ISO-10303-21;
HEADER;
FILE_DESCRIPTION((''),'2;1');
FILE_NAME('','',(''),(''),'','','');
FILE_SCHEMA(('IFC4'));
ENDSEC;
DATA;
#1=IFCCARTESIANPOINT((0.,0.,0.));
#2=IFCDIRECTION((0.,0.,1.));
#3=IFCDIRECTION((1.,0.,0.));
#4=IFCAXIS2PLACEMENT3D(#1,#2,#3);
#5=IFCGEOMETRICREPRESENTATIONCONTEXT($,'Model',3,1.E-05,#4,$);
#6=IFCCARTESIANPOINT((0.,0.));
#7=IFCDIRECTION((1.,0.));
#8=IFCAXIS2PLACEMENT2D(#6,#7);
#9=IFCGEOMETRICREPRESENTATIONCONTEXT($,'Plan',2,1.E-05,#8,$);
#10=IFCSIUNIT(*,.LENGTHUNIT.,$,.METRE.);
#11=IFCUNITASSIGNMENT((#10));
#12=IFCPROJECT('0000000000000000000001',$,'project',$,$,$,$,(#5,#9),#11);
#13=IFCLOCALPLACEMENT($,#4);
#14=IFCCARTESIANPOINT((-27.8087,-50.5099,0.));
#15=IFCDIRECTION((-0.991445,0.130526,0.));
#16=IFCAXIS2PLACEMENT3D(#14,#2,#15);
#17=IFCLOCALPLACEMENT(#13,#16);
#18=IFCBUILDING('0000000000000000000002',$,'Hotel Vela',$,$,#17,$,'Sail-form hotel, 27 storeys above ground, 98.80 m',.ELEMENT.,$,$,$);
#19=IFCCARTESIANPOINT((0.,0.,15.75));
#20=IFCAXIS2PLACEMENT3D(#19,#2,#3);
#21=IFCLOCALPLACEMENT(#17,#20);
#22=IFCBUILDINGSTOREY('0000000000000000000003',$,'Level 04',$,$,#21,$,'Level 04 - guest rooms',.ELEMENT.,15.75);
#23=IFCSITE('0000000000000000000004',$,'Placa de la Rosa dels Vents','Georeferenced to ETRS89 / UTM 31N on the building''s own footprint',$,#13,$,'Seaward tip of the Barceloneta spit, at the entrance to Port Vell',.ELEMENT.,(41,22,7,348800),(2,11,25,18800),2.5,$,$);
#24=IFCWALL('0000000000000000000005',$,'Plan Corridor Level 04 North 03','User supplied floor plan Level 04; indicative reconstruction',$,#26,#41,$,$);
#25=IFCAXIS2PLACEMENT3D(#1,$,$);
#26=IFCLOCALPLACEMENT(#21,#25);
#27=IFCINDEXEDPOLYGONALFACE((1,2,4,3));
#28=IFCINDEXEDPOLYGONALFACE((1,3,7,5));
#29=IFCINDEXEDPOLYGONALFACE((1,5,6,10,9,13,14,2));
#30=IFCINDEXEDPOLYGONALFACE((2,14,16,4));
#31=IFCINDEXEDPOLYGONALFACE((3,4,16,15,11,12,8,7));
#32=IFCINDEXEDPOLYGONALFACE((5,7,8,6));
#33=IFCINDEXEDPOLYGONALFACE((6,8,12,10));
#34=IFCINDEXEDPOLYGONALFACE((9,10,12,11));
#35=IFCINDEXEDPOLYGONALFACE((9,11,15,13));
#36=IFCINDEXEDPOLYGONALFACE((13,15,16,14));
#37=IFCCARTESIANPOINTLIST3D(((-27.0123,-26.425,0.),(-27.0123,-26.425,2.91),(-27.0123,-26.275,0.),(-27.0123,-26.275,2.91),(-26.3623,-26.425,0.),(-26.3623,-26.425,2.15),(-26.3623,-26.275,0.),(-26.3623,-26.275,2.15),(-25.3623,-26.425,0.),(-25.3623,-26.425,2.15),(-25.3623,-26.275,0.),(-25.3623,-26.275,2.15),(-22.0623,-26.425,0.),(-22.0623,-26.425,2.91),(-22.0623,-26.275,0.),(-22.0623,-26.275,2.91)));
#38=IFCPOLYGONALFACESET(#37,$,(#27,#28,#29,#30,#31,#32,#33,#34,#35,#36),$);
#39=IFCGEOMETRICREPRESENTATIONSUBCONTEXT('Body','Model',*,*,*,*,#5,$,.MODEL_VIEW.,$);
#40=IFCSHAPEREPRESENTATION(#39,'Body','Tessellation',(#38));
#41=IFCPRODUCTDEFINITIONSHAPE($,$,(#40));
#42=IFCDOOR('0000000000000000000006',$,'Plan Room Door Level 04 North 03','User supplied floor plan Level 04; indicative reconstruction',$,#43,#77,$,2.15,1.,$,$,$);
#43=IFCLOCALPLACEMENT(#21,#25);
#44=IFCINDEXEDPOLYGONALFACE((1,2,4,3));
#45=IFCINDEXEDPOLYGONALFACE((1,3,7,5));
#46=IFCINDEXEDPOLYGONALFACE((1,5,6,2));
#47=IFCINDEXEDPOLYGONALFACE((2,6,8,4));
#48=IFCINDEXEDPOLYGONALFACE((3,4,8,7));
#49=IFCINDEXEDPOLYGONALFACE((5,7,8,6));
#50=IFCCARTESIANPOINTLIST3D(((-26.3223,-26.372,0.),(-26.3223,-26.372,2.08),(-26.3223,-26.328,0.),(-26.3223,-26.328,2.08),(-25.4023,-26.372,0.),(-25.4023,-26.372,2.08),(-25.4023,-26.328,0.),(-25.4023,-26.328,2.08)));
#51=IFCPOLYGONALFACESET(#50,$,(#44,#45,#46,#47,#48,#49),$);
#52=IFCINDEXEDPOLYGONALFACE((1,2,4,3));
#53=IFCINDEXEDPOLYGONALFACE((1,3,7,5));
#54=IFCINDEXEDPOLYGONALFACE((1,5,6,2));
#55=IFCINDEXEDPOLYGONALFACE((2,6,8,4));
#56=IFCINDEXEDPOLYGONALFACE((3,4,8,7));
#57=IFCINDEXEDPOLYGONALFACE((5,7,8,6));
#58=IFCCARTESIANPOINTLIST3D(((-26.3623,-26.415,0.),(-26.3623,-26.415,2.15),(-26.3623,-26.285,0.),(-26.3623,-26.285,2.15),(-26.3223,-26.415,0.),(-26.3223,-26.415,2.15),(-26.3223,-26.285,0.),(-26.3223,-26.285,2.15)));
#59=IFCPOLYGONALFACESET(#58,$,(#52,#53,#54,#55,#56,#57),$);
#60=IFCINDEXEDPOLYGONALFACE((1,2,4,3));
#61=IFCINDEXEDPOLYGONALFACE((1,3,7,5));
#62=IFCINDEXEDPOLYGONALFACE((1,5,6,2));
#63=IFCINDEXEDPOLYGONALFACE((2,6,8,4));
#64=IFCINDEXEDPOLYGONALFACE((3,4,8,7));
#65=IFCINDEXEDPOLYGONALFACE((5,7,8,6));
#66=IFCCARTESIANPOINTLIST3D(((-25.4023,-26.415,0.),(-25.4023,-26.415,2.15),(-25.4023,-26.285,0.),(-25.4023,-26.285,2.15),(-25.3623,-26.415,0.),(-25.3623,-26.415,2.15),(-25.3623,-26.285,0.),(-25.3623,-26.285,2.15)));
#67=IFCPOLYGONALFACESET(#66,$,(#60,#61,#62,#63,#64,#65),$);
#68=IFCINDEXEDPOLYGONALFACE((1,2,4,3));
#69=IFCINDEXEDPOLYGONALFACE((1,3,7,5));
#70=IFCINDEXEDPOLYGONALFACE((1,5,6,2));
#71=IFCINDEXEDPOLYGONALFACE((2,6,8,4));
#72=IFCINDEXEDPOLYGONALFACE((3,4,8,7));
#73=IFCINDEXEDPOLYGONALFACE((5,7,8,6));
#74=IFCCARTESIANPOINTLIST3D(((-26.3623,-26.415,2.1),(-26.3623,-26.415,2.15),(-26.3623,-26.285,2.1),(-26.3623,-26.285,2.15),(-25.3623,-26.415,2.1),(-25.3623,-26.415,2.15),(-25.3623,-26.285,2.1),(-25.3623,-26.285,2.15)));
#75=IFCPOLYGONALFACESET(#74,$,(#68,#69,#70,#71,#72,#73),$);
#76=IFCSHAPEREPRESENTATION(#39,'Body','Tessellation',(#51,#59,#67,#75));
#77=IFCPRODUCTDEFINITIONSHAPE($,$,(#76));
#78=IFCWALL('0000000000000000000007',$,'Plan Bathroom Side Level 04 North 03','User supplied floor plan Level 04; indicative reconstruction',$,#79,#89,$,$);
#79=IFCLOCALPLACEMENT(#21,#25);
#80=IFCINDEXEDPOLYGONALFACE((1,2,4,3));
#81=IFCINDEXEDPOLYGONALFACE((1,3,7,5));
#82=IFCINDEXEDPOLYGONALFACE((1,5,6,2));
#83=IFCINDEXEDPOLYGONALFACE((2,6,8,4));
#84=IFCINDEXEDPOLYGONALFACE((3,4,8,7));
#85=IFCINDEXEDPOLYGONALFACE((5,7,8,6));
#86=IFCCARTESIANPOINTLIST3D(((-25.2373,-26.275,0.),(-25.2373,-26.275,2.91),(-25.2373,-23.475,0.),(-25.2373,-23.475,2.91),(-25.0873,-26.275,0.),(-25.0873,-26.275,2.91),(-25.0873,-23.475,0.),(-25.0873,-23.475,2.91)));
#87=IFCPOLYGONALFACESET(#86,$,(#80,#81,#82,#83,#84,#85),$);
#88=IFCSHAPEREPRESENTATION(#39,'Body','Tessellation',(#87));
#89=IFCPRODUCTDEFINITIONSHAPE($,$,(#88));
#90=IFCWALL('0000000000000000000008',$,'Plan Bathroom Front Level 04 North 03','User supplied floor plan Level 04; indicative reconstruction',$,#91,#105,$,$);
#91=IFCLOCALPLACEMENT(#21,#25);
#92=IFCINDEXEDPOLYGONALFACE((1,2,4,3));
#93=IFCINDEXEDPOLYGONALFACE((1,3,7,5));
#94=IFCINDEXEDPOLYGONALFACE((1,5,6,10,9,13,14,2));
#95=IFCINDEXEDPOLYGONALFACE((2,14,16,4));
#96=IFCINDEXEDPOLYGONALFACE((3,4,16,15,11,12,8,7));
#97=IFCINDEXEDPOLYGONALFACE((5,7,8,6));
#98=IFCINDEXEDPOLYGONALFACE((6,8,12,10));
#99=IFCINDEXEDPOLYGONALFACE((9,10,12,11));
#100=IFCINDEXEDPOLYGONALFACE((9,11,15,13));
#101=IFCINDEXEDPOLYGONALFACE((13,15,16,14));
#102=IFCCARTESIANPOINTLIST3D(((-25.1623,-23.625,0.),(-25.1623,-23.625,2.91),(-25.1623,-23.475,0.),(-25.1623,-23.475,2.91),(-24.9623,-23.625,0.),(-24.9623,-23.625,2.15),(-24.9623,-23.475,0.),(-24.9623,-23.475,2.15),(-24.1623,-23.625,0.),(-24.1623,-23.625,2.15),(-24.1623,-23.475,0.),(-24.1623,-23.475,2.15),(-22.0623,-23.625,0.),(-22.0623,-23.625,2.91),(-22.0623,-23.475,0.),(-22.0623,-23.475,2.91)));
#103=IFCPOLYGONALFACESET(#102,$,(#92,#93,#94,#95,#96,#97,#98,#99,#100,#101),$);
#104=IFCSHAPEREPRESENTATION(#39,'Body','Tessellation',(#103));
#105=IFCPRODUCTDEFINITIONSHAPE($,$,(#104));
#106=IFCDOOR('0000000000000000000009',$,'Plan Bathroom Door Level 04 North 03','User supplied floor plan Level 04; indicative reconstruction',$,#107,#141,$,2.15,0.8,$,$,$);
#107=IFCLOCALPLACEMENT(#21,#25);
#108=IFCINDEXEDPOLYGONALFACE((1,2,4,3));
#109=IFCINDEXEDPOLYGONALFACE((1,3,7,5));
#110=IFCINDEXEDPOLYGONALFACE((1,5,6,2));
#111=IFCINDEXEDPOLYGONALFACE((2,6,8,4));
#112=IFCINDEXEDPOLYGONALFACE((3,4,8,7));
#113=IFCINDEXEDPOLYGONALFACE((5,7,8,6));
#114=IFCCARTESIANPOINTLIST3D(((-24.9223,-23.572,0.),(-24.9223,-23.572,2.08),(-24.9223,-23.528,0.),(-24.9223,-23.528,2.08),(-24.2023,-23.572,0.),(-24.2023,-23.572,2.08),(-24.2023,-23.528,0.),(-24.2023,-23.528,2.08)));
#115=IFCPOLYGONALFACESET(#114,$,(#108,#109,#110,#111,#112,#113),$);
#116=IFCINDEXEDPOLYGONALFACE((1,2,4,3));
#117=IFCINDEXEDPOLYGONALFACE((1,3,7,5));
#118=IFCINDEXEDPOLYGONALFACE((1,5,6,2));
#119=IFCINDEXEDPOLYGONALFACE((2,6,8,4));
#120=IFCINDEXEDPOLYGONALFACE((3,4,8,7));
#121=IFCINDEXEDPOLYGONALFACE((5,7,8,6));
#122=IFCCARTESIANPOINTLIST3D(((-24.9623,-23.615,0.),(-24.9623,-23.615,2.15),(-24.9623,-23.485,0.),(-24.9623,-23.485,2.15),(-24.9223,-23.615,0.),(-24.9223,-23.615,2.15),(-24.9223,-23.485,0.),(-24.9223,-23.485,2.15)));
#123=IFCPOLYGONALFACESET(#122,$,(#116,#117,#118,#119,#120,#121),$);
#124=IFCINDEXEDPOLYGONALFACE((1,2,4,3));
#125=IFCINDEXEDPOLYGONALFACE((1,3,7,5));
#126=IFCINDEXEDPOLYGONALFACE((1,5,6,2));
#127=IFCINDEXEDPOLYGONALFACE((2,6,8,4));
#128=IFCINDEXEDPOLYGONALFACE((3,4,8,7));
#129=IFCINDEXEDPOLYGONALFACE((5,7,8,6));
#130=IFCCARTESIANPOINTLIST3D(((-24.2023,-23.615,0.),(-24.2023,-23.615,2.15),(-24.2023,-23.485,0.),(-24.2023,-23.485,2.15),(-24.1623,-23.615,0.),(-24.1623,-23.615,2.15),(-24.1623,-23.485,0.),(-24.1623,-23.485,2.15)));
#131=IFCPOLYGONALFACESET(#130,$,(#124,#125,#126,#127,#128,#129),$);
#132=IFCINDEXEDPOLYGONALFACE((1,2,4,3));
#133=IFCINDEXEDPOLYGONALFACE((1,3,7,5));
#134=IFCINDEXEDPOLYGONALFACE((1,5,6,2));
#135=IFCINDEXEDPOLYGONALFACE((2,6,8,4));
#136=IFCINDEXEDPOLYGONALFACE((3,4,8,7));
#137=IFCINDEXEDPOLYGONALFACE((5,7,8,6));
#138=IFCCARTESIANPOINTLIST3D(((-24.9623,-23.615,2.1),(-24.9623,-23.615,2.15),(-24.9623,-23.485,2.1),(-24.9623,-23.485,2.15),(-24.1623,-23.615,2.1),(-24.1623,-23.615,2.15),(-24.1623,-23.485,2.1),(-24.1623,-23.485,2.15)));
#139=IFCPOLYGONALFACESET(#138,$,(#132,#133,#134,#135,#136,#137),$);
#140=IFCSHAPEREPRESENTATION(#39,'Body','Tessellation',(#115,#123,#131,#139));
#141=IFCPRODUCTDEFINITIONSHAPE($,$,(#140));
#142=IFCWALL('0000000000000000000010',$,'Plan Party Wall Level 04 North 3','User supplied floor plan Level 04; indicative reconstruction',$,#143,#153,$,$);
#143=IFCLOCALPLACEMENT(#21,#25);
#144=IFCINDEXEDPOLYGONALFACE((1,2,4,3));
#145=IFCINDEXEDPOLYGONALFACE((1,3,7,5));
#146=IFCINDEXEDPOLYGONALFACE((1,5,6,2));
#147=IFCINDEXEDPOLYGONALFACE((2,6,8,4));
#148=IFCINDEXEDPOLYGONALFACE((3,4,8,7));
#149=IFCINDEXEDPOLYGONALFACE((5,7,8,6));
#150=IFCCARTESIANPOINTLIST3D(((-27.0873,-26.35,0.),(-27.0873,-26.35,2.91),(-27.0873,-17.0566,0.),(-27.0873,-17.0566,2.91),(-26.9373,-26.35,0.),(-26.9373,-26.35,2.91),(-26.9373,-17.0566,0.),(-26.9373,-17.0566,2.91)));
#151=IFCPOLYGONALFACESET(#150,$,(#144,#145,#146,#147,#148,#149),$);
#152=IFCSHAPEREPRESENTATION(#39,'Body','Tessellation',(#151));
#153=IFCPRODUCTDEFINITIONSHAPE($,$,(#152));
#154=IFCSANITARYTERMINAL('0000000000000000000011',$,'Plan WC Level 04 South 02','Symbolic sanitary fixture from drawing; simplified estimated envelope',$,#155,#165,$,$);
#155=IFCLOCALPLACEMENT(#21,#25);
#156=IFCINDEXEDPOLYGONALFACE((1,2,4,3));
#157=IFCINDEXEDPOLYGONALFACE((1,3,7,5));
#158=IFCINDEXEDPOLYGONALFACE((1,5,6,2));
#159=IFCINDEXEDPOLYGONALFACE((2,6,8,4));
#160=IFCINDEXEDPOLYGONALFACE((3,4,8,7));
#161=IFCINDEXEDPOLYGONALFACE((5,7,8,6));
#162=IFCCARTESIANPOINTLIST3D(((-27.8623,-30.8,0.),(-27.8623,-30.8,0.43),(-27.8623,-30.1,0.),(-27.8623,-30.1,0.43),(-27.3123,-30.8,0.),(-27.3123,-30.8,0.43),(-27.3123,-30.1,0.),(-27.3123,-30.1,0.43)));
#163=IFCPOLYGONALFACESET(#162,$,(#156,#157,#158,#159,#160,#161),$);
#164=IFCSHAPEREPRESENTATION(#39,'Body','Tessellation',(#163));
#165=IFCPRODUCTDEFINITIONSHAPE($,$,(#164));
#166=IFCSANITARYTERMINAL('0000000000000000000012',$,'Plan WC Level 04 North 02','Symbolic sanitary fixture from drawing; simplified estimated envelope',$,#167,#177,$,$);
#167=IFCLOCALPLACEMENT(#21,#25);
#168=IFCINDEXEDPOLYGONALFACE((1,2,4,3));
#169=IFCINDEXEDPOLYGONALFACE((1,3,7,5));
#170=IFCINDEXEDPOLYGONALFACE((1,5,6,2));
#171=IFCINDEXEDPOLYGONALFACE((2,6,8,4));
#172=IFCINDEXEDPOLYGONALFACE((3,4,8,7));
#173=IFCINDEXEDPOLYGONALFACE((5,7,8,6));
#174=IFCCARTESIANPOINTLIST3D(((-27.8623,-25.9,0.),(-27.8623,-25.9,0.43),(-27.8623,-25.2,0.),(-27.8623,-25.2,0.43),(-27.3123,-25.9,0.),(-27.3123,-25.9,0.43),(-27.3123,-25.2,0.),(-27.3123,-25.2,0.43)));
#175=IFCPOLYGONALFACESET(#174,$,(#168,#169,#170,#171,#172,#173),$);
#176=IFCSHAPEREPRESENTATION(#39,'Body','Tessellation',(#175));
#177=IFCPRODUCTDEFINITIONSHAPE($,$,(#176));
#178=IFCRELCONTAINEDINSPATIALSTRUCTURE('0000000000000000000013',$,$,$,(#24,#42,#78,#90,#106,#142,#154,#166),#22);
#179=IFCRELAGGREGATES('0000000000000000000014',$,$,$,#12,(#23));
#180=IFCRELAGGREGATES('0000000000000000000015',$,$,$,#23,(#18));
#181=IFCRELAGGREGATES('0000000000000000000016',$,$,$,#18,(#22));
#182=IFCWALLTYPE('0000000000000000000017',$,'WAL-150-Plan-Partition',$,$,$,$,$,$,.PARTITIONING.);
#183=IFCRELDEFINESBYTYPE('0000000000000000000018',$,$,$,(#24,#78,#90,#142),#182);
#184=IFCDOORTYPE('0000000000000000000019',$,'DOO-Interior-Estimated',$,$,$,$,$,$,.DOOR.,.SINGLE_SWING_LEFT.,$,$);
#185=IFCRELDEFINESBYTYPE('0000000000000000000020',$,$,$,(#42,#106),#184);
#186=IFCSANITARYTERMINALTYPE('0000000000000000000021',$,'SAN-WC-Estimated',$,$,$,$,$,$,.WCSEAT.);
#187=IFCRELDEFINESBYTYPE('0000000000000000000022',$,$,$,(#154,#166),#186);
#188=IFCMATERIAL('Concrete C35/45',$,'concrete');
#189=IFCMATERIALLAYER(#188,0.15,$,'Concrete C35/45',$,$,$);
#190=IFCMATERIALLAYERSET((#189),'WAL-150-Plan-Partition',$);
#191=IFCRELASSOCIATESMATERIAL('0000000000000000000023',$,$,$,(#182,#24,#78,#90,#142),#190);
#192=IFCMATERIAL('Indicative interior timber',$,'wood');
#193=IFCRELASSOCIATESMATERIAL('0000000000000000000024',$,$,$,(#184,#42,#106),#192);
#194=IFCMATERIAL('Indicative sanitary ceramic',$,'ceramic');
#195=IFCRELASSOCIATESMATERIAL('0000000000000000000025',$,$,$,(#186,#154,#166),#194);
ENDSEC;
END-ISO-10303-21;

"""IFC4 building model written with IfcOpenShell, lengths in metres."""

from ifc_helpers import new_model, si_unit, frame, origin_with_axes, origin_2d_with_axis, place, context, subcontext, project, spatial, line, indexed_curve, outline, extrude, material, layer, layer_set, layer_usage, type_object, element, fill, save


model = new_model("IFC4")

# Units and contexts
model_context = context("Model", 3, precision=1e-05, world=origin_with_axes())
plan_context = context("Plan", 2, precision=1e-05, world=origin_2d_with_axis())
body_context = subcontext(model_context, "Body", "Model", "MODEL_VIEW")
ifc_project = project(units=[si_unit("LENGTHUNIT", "METRE")], contexts=[model_context, plan_context])

# Site, building, storey
site_placement = place(None, origin_with_axes())
site = spatial("IfcSite", under=ifc_project, at=site_placement, Name="Placa de la Rosa dels Vents", Description="Georeferenced to ETRS89 / UTM 31N on the building's own footprint", LongName="Seaward tip of the Barceloneta spit, at the entrance to Port Vell", CompositionType="ELEMENT", RefLatitude=(41, 22, 7, 348800), RefLongitude=(2, 11, 25, 18800), RefElevation=2.5)
building_placement = place(site_placement, frame((-27.8087, -50.5099, 0.0), z_axis=(0.0, 0.0, 1.0), x_axis=(-0.991445, 0.130526, 0.0)))
building = spatial("IfcBuilding", under=site, at=building_placement, Name="Hotel Vela", LongName="Sail-form hotel, 27 storeys above ground, 98.80 m", CompositionType="ELEMENT")
storey_placement = place(building_placement, frame((0.0, 0.0, 15.75), z_axis=(0.0, 0.0, 1.0), x_axis=(1.0, 0.0, 0.0)))
storey = spatial("IfcBuildingStorey", under=building, at=storey_placement, Name="Level 04", LongName="Level 04 - guest rooms", CompositionType="ELEMENT", Elevation=15.75)

# Shared definitions
ifc_material_1 = material(Name="Concrete C35/45", Category="concrete")
ifc_layer = layer(ifc_material_1, 0.15, Name="Concrete C35/45")
ifc_layer_set = layer_set([ifc_layer], Name="WAL-150-Plan-Partition")
wall_type = type_object("IfcWallType", Name="WAL-150-Plan-Partition", PredefinedType="PARTITIONING", material=ifc_layer_set)

# Shared definitions
ifc_material_2 = material(Name="Indicative interior timber", Category="wood")
door_type = type_object("IfcDoorType", Name="DOO-Interior-Estimated", OperationType="SINGLE_SWING_LEFT", PredefinedType="DOOR", material=ifc_material_2)

# Wall, opening, door
ifc_layer_usage_1 = layer_usage(ifc_layer_set, "AXIS2", "POSITIVE", 0.0)
wall_1_placement = place(storey_placement, frame((-27.0123, -26.425, 0.0), z_axis=(0.0, 0.0, 1.0), x_axis=(1.0, 0.0, 0.0)))
wall_1 = element("IfcWall", 1, at=wall_1_placement, inside=storey, type_object=wall_type, material=ifc_layer_usage_1, Name="Plan Corridor Level 04 North 03", Description="User supplied floor plan Level 04; indicative reconstruction", context=body_context, shape_type="SweptSolid", body=[
    extrude(outline(indexed_curve([(0.0, 0.0), (4.95, 0.0), (4.95, 0.15), (0.0, 0.15)], segments=[line(1, 2, 3, 4, 1)])), origin_with_axes(), (0.0, 0.0, 1.0), 2.91),
])
opening_1_placement = place(wall_1_placement, frame((0.65, -0.085, 0.0), z_axis=(0.0, 0.0, 1.0), x_axis=(1.0, 0.0, 0.0)))
opening_1 = element("IfcOpeningElement", 2, at=opening_1_placement, cuts=wall_1, PredefinedType="OPENING", context=body_context, shape_type="SweptSolid", body=[
    extrude(outline(indexed_curve([(0.0, 0.0), (1.0, 0.0), (1.0, 0.32), (0.0, 0.32)], segments=[line(1, 2, 3, 4, 1)])), origin_with_axes(), (0.0, 0.0, 1.0), 2.15),
])
door_1_placement = place(storey_placement, frame((0.0, 0.0, -15.75), z_axis=(0.0, 0.0, 1.0), x_axis=(1.0, 0.0, 0.0)))
door_1 = element("IfcDoor", 3, at=door_1_placement, inside=storey, type_object=door_type, material=ifc_material_2, Name="Plan Room Door Level 04 North 03", Description="User supplied floor plan Level 04; indicative reconstruction", OverallHeight=2.15, OverallWidth=1.0, context=body_context, shape_type="SweptSolid", body=[
    extrude(outline(indexed_curve([(0.0, 0.0), (0.92, 0.0), (0.92, 0.044), (0.0, 0.044)], segments=[line(1, 2, 3, 4, 1)])), frame((-26.3223, -26.372, 15.75), z_axis=(0.0, 0.0, 1.0), x_axis=(1.0, 0.0, 0.0)), (0.0, 0.0, 1.0), 2.08),
    extrude(outline(indexed_curve([(0.0, 0.0), (0.04, 0.0), (0.04, 0.13), (0.0, 0.13)], segments=[line(1, 2, 3, 4, 1)])), frame((-26.3623, -26.415, 15.75), z_axis=(0.0, 0.0, 1.0), x_axis=(1.0, 0.0, 0.0)), (0.0, 0.0, 1.0), 2.15),
    extrude(outline(indexed_curve([(0.0, 0.0), (0.04, 0.0), (0.04, 0.13), (0.0, 0.13)], segments=[line(1, 2, 3, 4, 1)])), frame((-25.4023, -26.415, 15.75), z_axis=(0.0, 0.0, 1.0), x_axis=(1.0, 0.0, 0.0)), (0.0, 0.0, 1.0), 2.15),
    extrude(outline(indexed_curve([(0.0, 0.0), (1.0, 0.0), (1.0, 0.13), (0.0, 0.13)], segments=[line(1, 2, 3, 4, 1)])), frame((-26.3623, -26.415, 17.85), z_axis=(0.0, 0.0, 1.0), x_axis=(1.0, 0.0, 0.0)), (0.0, 0.0, 1.0), 0.05),
])
fill(opening_1, door_1)

# Wall
ifc_layer_usage_2 = layer_usage(ifc_layer_set, "AXIS2", "POSITIVE", 0.0)
wall_2_placement = place(storey_placement, frame((-25.2373, -26.275, 0.0), z_axis=(0.0, 0.0, 1.0), x_axis=(1.0, 0.0, 0.0)))
element("IfcWall", 4, at=wall_2_placement, inside=storey, type_object=wall_type, material=ifc_layer_usage_2, Name="Plan Bathroom Side Level 04 North 03", Description="User supplied floor plan Level 04; indicative reconstruction", context=body_context, shape_type="SweptSolid", body=[
    extrude(outline(indexed_curve([(0.0, 0.0), (0.15, 0.0), (0.15, 2.8), (0.0, 2.8)], segments=[line(1, 2, 3, 4, 1)])), origin_with_axes(), (0.0, 0.0, 1.0), 2.91),
])

# Wall, opening, door
ifc_layer_usage_3 = layer_usage(ifc_layer_set, "AXIS2", "POSITIVE", 0.0)
wall_3_placement = place(storey_placement, frame((-25.1623, -23.625, 0.0), z_axis=(0.0, 0.0, 1.0), x_axis=(1.0, 0.0, 0.0)))
wall_3 = element("IfcWall", 5, at=wall_3_placement, inside=storey, type_object=wall_type, material=ifc_layer_usage_3, Name="Plan Bathroom Front Level 04 North 03", Description="User supplied floor plan Level 04; indicative reconstruction", context=body_context, shape_type="SweptSolid", body=[
    extrude(outline(indexed_curve([(0.0, 0.0), (3.1, 0.0), (3.1, 0.15), (0.0, 0.15)], segments=[line(1, 2, 3, 4, 1)])), origin_with_axes(), (0.0, 0.0, 1.0), 2.91),
])
opening_2_placement = place(wall_3_placement, frame((0.2, -0.085, 0.0), z_axis=(0.0, 0.0, 1.0), x_axis=(1.0, 0.0, 0.0)))
opening_2 = element("IfcOpeningElement", 6, at=opening_2_placement, cuts=wall_3, PredefinedType="OPENING", context=body_context, shape_type="SweptSolid", body=[
    extrude(outline(indexed_curve([(0.0, 0.0), (0.8, 0.0), (0.8, 0.32), (0.0, 0.32)], segments=[line(1, 2, 3, 4, 1)])), origin_with_axes(), (0.0, 0.0, 1.0), 2.15),
])
door_2_placement = place(storey_placement, frame((0.0, 0.0, -15.75), z_axis=(0.0, 0.0, 1.0), x_axis=(1.0, 0.0, 0.0)))
door_2 = element("IfcDoor", 7, at=door_2_placement, inside=storey, type_object=door_type, material=ifc_material_2, Name="Plan Bathroom Door Level 04 North 03", Description="User supplied floor plan Level 04; indicative reconstruction", OverallHeight=2.15, OverallWidth=0.8, context=body_context, shape_type="SweptSolid", body=[
    extrude(outline(indexed_curve([(0.0, 0.0), (0.72, 0.0), (0.72, 0.044), (0.0, 0.044)], segments=[line(1, 2, 3, 4, 1)])), frame((-24.9223, -23.572, 15.75), z_axis=(0.0, 0.0, 1.0), x_axis=(1.0, 0.0, 0.0)), (0.0, 0.0, 1.0), 2.08),
    extrude(outline(indexed_curve([(0.0, 0.0), (0.04, 0.0), (0.04, 0.13), (0.0, 0.13)], segments=[line(1, 2, 3, 4, 1)])), frame((-24.9623, -23.615, 15.75), z_axis=(0.0, 0.0, 1.0), x_axis=(1.0, 0.0, 0.0)), (0.0, 0.0, 1.0), 2.15),
    extrude(outline(indexed_curve([(0.0, 0.0), (0.04, 0.0), (0.04, 0.13), (0.0, 0.13)], segments=[line(1, 2, 3, 4, 1)])), frame((-24.2023, -23.615, 15.75), z_axis=(0.0, 0.0, 1.0), x_axis=(1.0, 0.0, 0.0)), (0.0, 0.0, 1.0), 2.15),
    extrude(outline(indexed_curve([(0.0, 0.0), (0.8, 0.0), (0.8, 0.13), (0.0, 0.13)], segments=[line(1, 2, 3, 4, 1)])), frame((-24.9623, -23.615, 17.85), z_axis=(0.0, 0.0, 1.0), x_axis=(1.0, 0.0, 0.0)), (0.0, 0.0, 1.0), 0.05),
])
fill(opening_2, door_2)

# Wall
ifc_layer_usage_4 = layer_usage(ifc_layer_set, "AXIS2", "POSITIVE", 0.0)
wall_4_placement = place(storey_placement, frame((-27.0873, -26.35, 0.0), z_axis=(0.0, 0.0, 1.0), x_axis=(1.0, 0.0, 0.0)))
element("IfcWall", 8, at=wall_4_placement, inside=storey, type_object=wall_type, material=ifc_layer_usage_4, Name="Plan Party Wall Level 04 North 3", Description="User supplied floor plan Level 04; indicative reconstruction", context=body_context, shape_type="SweptSolid", body=[
    extrude(outline(indexed_curve([(0.0, 0.0), (0.15, 0.0), (0.15, 9.2934), (0.0, 9.2934)], segments=[line(1, 2, 3, 4, 1)])), origin_with_axes(), (0.0, 0.0, 1.0), 2.91),
])

# Sanitary terminals
ifc_material_3 = material(Name="Indicative sanitary ceramic", Category="ceramic")
sanitary_terminal_type_1 = type_object("IfcSanitaryTerminalType", Name="SAN-WC-Estimated", PredefinedType="WCSEAT", material=ifc_material_3)
for number, where, z_axis, x_axis, name in (
    (9, (-27.8623, -30.8, 0.0), (0.0, 0.0, 1.0), (1.0, 0.0, 0.0), "Plan WC Level 04 South 02"),
    (10, (-27.8623, -25.9, 0.0), (0.0, 0.0, 1.0), (1.0, 0.0, 0.0), "Plan WC Level 04 North 02"),
):
    element("IfcSanitaryTerminal", number, at=place(storey_placement, frame(where, z_axis=z_axis, x_axis=x_axis)), inside=storey, type_object=sanitary_terminal_type_1, material=ifc_material_3, Name=name, Description="Symbolic sanitary fixture from drawing; simplified estimated envelope", context=body_context, shape_type="SweptSolid", body=[
        extrude(outline(indexed_curve([(0.0, 0.0), (0.55, 0.0), (0.55, 0.7), (0.0, 0.7)], segments=[line(1, 2, 3, 4, 1)])), origin_with_axes(), (0.0, 0.0, 1.0), 0.43),
    ])

save(model, "model.ifc")
